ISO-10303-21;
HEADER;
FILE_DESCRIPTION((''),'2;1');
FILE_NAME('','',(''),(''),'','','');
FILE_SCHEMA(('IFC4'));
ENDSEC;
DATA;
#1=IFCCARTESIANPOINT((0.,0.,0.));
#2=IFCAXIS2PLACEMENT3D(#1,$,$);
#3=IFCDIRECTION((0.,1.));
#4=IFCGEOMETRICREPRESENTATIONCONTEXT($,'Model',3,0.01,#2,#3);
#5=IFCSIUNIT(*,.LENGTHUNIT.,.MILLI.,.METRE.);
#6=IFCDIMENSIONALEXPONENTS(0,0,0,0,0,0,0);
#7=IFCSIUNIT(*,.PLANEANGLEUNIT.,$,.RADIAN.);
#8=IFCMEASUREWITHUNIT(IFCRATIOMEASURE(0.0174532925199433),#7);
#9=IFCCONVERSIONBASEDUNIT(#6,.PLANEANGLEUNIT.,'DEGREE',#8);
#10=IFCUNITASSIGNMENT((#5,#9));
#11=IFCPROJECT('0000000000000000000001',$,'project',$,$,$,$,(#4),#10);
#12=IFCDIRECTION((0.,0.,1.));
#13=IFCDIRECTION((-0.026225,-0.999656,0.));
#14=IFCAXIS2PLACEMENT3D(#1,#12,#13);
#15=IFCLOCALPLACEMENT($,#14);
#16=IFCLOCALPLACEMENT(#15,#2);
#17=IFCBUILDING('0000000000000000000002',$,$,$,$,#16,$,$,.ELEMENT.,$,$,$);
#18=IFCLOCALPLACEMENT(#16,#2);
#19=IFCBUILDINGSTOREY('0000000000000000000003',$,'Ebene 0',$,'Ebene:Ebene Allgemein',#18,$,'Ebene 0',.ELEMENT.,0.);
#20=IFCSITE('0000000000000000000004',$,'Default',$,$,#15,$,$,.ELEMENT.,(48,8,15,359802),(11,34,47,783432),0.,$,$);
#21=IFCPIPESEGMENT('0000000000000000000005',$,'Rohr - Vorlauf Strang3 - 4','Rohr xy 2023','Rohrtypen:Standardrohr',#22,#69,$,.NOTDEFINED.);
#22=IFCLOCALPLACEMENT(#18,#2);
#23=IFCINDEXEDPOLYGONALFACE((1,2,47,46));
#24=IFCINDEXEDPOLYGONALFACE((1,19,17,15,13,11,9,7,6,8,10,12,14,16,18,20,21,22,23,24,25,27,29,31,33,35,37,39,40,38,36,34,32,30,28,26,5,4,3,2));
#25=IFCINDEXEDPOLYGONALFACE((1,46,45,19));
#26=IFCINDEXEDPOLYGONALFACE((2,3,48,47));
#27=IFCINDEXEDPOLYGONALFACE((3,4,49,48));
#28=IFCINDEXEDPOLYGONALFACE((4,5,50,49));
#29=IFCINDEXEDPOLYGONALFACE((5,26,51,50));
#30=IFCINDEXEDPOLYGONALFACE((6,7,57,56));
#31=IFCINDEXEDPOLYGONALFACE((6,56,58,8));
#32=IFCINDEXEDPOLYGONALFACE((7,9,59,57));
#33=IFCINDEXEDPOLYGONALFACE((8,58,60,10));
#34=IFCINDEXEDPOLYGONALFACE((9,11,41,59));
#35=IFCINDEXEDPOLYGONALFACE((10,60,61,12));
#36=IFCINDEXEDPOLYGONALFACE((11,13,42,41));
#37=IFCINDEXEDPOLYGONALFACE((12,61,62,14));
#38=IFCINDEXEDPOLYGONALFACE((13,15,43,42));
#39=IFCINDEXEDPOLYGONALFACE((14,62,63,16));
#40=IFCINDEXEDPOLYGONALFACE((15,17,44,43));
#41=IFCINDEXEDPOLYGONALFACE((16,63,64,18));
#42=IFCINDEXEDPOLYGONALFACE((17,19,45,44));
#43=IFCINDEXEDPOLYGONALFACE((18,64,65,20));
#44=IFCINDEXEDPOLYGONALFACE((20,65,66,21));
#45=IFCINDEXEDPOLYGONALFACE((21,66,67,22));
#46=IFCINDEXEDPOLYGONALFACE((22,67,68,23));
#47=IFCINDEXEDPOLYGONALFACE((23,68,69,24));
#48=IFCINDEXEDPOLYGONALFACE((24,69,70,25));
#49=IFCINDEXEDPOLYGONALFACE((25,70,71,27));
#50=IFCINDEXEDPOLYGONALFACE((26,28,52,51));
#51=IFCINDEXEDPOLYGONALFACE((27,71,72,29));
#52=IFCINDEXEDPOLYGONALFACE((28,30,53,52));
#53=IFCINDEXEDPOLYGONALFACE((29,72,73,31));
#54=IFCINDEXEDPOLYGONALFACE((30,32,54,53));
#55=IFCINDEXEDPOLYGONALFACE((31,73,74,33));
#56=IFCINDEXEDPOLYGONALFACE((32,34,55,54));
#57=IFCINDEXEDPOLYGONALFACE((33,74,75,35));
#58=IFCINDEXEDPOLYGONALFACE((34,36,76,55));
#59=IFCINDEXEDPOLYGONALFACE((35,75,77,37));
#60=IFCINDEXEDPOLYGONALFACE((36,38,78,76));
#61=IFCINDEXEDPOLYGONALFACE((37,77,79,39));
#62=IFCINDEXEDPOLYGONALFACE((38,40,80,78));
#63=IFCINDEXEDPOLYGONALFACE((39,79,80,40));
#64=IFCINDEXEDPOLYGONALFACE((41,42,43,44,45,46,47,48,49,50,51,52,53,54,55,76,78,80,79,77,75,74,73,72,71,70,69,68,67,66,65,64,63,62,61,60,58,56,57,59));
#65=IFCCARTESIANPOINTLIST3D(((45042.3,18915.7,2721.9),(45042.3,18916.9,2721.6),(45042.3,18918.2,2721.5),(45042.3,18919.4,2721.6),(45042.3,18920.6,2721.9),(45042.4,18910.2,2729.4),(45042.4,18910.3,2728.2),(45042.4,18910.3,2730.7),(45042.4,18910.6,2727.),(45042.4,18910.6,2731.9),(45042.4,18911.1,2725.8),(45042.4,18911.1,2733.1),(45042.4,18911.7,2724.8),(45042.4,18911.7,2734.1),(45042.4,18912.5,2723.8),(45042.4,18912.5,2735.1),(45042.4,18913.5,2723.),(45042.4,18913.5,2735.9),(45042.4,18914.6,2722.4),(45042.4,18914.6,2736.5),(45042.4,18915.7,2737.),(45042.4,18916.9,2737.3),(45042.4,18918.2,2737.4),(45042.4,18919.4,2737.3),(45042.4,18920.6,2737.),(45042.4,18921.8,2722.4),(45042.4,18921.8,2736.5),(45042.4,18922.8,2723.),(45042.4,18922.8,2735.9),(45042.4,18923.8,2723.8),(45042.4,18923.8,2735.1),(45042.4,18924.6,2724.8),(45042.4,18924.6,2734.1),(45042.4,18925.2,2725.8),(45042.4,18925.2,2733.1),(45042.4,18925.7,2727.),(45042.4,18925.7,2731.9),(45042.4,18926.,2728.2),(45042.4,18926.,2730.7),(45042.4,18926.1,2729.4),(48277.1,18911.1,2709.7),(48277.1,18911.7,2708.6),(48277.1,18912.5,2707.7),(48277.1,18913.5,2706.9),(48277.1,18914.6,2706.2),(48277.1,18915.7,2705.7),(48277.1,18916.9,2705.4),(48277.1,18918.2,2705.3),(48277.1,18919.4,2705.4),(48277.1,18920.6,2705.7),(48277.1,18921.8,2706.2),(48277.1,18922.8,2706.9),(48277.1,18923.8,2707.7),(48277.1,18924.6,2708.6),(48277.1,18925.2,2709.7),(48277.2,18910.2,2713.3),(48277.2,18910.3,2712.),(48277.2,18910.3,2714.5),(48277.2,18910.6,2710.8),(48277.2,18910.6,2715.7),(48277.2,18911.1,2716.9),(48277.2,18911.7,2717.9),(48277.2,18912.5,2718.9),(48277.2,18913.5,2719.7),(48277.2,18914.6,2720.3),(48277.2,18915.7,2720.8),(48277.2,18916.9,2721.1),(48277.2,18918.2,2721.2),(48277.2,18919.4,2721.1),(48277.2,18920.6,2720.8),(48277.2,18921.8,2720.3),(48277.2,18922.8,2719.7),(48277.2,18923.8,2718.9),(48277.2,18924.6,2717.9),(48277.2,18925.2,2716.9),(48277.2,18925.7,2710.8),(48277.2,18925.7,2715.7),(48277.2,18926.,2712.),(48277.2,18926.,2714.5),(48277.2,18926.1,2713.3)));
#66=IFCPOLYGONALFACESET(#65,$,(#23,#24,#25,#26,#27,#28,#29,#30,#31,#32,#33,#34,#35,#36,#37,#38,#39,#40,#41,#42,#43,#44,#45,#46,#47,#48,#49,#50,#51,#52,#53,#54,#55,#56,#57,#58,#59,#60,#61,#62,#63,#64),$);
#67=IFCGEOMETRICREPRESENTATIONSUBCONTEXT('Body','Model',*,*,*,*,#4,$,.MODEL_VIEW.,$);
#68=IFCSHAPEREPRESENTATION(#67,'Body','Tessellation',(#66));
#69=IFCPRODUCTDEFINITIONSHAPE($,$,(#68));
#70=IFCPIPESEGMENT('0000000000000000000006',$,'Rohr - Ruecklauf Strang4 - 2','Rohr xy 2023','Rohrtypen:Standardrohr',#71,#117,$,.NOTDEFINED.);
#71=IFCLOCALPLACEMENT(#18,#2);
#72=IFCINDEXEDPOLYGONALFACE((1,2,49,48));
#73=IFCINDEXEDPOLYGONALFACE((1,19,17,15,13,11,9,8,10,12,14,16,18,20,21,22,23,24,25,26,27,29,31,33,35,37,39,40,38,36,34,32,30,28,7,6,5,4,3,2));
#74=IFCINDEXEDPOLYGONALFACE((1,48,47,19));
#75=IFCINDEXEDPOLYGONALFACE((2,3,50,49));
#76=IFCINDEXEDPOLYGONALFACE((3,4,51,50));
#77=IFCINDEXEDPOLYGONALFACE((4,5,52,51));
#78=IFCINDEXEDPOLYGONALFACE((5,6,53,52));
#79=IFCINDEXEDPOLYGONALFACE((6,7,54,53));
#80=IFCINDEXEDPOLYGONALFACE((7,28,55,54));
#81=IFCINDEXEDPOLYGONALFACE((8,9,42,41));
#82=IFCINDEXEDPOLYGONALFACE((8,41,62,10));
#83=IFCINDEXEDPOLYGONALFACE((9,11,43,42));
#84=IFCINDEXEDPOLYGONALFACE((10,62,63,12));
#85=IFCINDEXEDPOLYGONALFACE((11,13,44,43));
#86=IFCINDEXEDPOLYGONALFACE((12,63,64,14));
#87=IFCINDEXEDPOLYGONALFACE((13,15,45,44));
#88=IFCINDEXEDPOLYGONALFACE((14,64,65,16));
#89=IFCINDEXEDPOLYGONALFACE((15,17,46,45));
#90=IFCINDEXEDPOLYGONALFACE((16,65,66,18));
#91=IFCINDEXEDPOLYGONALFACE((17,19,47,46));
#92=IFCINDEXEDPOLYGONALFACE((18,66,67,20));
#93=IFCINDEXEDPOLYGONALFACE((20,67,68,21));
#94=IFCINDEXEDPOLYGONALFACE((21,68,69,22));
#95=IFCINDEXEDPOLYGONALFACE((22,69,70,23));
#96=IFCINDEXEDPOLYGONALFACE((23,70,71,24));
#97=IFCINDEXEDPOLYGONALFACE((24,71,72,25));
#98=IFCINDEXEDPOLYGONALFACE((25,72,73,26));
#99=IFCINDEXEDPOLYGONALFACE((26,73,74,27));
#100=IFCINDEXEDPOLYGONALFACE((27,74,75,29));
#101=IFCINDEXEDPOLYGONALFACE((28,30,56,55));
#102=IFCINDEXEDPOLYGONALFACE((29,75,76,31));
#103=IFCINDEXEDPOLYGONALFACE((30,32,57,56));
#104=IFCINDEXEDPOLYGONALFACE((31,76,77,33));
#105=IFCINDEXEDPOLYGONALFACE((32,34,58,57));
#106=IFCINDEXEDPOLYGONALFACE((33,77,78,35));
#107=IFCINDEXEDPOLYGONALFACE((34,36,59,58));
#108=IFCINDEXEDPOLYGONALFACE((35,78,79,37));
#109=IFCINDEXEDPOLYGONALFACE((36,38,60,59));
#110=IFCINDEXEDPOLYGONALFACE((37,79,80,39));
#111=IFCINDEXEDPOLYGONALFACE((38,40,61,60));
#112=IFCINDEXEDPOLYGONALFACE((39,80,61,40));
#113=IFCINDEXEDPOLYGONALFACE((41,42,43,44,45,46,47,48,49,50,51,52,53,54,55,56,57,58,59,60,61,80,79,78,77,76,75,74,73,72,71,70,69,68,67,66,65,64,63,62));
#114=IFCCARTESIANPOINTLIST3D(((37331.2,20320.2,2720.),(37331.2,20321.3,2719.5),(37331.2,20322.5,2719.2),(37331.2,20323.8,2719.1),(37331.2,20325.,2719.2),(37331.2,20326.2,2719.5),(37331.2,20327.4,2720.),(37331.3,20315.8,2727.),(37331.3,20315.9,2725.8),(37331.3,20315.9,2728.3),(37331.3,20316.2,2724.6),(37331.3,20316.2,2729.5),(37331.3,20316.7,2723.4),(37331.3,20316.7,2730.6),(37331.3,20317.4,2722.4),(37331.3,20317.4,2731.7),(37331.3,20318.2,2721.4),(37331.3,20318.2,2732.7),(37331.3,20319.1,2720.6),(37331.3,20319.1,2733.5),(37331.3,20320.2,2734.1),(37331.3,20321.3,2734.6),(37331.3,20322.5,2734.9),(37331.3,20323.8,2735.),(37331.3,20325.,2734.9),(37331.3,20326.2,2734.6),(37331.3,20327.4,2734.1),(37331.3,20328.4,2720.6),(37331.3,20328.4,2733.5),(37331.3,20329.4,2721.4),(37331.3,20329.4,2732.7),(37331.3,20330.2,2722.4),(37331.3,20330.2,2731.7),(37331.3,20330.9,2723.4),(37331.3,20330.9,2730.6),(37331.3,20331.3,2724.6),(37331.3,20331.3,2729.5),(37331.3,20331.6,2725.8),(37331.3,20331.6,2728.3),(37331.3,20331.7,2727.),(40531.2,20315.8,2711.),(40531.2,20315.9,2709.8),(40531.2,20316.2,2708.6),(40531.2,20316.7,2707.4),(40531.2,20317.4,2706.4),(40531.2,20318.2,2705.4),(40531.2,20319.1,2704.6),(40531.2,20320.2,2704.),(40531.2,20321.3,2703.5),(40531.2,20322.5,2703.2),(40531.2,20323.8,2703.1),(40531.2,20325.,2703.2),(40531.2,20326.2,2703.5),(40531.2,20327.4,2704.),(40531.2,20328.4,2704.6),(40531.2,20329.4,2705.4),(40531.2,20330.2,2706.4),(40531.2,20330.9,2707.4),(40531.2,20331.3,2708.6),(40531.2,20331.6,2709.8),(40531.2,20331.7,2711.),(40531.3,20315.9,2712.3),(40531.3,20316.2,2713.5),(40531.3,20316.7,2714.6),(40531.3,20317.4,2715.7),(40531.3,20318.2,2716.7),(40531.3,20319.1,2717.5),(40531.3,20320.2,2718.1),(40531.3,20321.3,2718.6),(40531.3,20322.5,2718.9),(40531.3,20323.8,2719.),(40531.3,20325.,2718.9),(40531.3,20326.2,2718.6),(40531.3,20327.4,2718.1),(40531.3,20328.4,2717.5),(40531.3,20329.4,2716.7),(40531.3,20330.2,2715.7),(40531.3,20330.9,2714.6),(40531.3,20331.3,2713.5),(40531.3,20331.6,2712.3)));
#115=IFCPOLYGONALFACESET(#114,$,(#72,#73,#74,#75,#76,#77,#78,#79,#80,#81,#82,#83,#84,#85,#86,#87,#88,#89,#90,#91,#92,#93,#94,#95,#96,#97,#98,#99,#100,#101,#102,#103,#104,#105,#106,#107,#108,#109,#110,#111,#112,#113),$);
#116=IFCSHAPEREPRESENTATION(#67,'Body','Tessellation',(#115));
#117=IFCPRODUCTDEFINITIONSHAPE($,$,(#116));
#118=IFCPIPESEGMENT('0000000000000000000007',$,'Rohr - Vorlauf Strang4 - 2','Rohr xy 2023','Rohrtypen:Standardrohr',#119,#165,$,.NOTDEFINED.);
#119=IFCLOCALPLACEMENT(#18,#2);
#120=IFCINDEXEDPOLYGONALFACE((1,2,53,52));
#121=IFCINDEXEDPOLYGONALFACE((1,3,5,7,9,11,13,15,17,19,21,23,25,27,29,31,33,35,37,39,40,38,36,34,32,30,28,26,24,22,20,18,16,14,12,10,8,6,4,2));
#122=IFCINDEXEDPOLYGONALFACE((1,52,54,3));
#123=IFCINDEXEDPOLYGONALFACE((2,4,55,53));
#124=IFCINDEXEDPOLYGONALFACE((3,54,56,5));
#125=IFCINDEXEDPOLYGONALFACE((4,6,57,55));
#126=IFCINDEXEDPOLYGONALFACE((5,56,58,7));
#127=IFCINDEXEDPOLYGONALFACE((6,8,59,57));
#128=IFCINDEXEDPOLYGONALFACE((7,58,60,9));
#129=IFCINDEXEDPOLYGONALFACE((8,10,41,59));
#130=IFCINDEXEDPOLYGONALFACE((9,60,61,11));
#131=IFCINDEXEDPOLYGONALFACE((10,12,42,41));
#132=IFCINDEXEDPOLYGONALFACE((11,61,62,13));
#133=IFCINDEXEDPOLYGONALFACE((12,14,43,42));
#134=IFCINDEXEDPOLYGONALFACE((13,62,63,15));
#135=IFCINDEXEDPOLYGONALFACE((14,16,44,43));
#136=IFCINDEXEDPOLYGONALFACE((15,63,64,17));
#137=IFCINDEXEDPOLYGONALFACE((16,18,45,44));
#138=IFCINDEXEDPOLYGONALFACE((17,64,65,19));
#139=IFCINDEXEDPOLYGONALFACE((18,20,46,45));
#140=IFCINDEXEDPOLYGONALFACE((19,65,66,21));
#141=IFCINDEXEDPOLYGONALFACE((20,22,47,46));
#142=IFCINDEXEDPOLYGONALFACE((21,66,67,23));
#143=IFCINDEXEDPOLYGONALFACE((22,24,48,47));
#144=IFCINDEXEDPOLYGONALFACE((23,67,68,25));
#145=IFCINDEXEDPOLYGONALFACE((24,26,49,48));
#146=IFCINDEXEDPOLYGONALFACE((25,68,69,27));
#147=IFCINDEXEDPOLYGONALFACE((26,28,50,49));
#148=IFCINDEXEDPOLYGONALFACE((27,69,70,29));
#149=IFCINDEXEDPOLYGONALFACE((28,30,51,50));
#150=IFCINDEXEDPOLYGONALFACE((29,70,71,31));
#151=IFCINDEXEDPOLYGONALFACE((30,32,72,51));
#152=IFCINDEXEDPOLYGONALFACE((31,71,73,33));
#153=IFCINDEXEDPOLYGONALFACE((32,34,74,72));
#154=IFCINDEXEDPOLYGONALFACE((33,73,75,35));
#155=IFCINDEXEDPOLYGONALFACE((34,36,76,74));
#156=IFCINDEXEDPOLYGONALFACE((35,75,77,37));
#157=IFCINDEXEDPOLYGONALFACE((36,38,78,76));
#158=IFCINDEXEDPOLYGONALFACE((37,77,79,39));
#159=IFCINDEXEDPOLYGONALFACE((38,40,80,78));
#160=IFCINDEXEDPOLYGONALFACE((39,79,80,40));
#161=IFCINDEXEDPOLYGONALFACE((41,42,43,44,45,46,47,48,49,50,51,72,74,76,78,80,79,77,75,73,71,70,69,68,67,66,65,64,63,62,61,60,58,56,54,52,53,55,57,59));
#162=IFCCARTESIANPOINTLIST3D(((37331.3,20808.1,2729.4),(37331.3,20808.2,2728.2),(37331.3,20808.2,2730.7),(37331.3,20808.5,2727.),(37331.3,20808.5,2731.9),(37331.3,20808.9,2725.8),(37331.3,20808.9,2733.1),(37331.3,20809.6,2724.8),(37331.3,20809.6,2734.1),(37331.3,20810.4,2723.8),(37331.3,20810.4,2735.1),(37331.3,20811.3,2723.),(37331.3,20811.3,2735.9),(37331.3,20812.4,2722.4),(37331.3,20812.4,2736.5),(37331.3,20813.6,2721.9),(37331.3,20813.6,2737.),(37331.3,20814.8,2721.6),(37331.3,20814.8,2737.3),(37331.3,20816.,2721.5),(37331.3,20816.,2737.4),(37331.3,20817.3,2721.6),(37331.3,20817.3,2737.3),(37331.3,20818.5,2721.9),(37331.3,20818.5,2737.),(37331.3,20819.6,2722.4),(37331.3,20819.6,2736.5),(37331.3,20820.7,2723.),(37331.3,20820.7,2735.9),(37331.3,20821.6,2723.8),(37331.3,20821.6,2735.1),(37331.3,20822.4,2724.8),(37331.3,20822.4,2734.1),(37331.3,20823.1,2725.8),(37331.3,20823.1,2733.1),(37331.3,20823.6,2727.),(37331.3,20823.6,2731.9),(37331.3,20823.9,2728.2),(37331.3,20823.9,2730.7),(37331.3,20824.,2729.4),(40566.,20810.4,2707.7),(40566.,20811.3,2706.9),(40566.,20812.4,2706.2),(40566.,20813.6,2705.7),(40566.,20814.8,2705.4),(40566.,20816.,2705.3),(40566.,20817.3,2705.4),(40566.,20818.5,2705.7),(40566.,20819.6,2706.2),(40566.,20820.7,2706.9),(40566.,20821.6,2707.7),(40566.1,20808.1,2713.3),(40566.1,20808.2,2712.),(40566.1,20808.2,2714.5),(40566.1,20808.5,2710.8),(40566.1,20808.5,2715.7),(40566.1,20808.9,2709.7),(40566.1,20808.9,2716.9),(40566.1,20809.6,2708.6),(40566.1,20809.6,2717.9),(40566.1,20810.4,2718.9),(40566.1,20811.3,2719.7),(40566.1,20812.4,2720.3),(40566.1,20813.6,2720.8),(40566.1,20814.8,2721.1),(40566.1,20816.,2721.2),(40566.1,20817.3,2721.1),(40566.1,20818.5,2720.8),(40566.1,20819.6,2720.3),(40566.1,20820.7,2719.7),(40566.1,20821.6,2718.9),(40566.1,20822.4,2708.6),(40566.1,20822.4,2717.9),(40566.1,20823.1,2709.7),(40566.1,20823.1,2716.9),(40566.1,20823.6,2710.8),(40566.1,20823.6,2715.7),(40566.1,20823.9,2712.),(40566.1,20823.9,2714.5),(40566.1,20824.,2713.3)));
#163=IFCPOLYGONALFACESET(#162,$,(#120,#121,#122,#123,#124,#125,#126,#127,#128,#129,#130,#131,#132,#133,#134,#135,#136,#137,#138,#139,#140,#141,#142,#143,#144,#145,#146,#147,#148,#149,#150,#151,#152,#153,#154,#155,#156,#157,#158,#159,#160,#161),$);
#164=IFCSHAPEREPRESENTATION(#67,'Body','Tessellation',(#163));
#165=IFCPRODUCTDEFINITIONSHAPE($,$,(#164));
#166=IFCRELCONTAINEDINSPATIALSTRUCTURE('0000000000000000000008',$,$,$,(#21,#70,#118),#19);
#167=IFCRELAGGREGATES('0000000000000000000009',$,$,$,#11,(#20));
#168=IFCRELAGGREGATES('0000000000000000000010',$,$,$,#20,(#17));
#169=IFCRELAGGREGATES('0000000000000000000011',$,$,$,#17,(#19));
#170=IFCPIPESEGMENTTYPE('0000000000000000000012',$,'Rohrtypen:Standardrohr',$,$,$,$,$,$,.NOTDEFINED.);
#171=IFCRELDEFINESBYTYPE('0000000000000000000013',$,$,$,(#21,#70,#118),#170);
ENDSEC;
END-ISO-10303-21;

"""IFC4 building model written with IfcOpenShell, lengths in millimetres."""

from ifc_helpers import new_model, entity, si_unit, converted_unit, direction, frame, origin, place, context, subcontext, project, spatial, indexed_curve, outline, extrude, type_object, element, save


model = new_model("IFC4")

# Units and contexts
model_context = context("Model", 3, precision=0.01, world=origin(), true_north=direction((0.0, 1.0)))
body_context = subcontext(model_context, "Body", "Model", "MODEL_VIEW")
ifc_project = project(units=[si_unit("LENGTHUNIT", "METRE", prefix="MILLI"), converted_unit("PLANEANGLEUNIT", "DEGREE", entity("IfcRatioMeasure", 0.0174532925199433), si_unit("PLANEANGLEUNIT", "RADIAN"), dimensions=[0, 0, 0, 0, 0, 0, 0])], contexts=[model_context])

# Site, building, storey
site_placement = place(None, frame((0.0, 0.0, 0.0), z_axis=(0.0, 0.0, 1.0), x_axis=(-0.026225, -0.999656, 0.0)))
site = spatial("IfcSite", under=ifc_project, at=site_placement, Name="Default", CompositionType="ELEMENT", RefLatitude=(48, 8, 15, 359802), RefLongitude=(11, 34, 47, 783432), RefElevation=0.0)
building_placement = place(site_placement, origin())
building = spatial("IfcBuilding", under=site, at=building_placement, CompositionType="ELEMENT")
storey_placement = place(building_placement, origin())
storey = spatial("IfcBuildingStorey", under=building, at=storey_placement, Name="Ebene 0", ObjectType="Ebene:Ebene Allgemein", LongName="Ebene 0", CompositionType="ELEMENT", Elevation=0.0)

# Pipe segments
pipe_segment_type = type_object("IfcPipeSegmentType", Name="Rohrtypen:Standardrohr", PredefinedType="NOTDEFINED")
pipe_segment_1_placement = place(storey_placement, origin())
element("IfcPipeSegment", 1, at=pipe_segment_1_placement, inside=storey, type_object=pipe_segment_type, Name="Rohr - Vorlauf Strang3 - 4", Description="Rohr xy 2023", ObjectType="Rohrtypen:Standardrohr", PredefinedType="NOTDEFINED", context=body_context, shape_type="SweptSolid", body=[
    extrude(outline(indexed_curve([(7.9, 0.0), (7.8, 1.2), (7.6, 2.5), (7.1, 3.6), (6.4, 4.7), (5.6, 5.6), (4.7, 6.4), (3.6, 7.1), (2.5, 7.6), (1.2, 7.8), (0.0, 7.9), (-1.2, 7.8), (-2.5, 7.6), (-3.6, 7.1), (-4.7, 6.4), (-5.6, 5.6), (-6.4, 4.7), (-7.1, 3.6), (-7.6, 2.5), (-7.8, 1.2), (-7.9, 0.0), (-7.8, -1.2), (-7.6, -2.5), (-7.1, -3.6), (-6.4, -4.7), (-5.6, -5.6), (-4.7, -6.4), (-3.6, -7.1), (-2.5, -7.6), (-1.2, -7.8), (0.0, -7.9), (1.2, -7.8), (2.5, -7.6), (3.6, -7.1), (4.7, -6.4), (5.6, -5.6), (6.4, -4.7), (7.1, -3.6), (7.6, -2.5), (7.8, -1.2), (7.9, 0.0)], self_intersect=False)), frame((48277.2, 18918.2, 2713.3), z_axis=(-0.999988, 0.0, 0.005), x_axis=(0.0, 1.0, 0.0)), (0.0, 0.0, 1.0), 3234.8),
])
pipe_segment_2_placement = place(storey_placement, origin())
element("IfcPipeSegment", 2, at=pipe_segment_2_placement, inside=storey, type_object=pipe_segment_type, Name="Rohr - Ruecklauf Strang4 - 2", Description="Rohr xy 2023", ObjectType="Rohrtypen:Standardrohr", PredefinedType="NOTDEFINED", context=body_context, shape_type="SweptSolid", body=[
    extrude(outline(indexed_curve([(7.9, 0.0), (7.8, 1.2), (7.6, 2.5), (7.1, 3.6), (6.4, 4.7), (5.6, 5.6), (4.7, 6.4), (3.6, 7.1), (2.5, 7.6), (1.2, 7.8), (0.0, 7.9), (-1.2, 7.8), (-2.5, 7.6), (-3.6, 7.1), (-4.7, 6.4), (-5.6, 5.6), (-6.4, 4.7), (-7.1, 3.6), (-7.6, 2.5), (-7.8, 1.2), (-7.9, 0.0), (-7.8, -1.2), (-7.6, -2.5), (-7.1, -3.6), (-6.4, -4.7), (-5.6, -5.6), (-4.7, -6.4), (-3.6, -7.1), (-2.5, -7.6), (-1.2, -7.8), (0.0, -7.9), (1.2, -7.8), (2.5, -7.6), (3.6, -7.1), (4.7, -6.4), (5.6, -5.6), (6.4, -4.7), (7.1, -3.6), (7.6, -2.5), (7.8, -1.2), (7.9, 0.0)], self_intersect=False)), frame((40531.2, 20323.8, 2711.0), z_axis=(-0.999988, 0.0, 0.005), x_axis=(0.0, 1.0, 0.0)), (0.0, 0.0, 1.0), 3200.0),
])
pipe_segment_3_placement = place(storey_placement, origin())
element("IfcPipeSegment", 3, at=pipe_segment_3_placement, inside=storey, type_object=pipe_segment_type, Name="Rohr - Vorlauf Strang4 - 2", Description="Rohr xy 2023", ObjectType="Rohrtypen:Standardrohr", PredefinedType="NOTDEFINED", context=body_context, shape_type="SweptSolid", body=[
    extrude(outline(indexed_curve([(7.9, 0.0), (7.8, 1.2), (7.6, 2.5), (7.1, 3.6), (6.4, 4.7), (5.6, 5.6), (4.7, 6.4), (3.6, 7.1), (2.5, 7.6), (1.2, 7.8), (0.0, 7.9), (-1.2, 7.8), (-2.5, 7.6), (-3.6, 7.1), (-4.7, 6.4), (-5.6, 5.6), (-6.4, 4.7), (-7.1, 3.6), (-7.6, 2.5), (-7.8, 1.2), (-7.9, 0.0), (-7.8, -1.2), (-7.6, -2.5), (-7.1, -3.6), (-6.4, -4.7), (-5.6, -5.6), (-4.7, -6.4), (-3.6, -7.1), (-2.5, -7.6), (-1.2, -7.8), (0.0, -7.9), (1.2, -7.8), (2.5, -7.6), (3.6, -7.1), (4.7, -6.4), (5.6, -5.6), (6.4, -4.7), (7.1, -3.6), (7.6, -2.5), (7.8, -1.2), (7.9, 0.0)], self_intersect=False)), frame((40566.1, 20816.0, 2713.3), z_axis=(-0.999988, 0.0, 0.005), x_axis=(0.0, 1.0, 0.0)), (0.0, 0.0, 1.0), 3234.8),
])

save(model, "model.ifc")
